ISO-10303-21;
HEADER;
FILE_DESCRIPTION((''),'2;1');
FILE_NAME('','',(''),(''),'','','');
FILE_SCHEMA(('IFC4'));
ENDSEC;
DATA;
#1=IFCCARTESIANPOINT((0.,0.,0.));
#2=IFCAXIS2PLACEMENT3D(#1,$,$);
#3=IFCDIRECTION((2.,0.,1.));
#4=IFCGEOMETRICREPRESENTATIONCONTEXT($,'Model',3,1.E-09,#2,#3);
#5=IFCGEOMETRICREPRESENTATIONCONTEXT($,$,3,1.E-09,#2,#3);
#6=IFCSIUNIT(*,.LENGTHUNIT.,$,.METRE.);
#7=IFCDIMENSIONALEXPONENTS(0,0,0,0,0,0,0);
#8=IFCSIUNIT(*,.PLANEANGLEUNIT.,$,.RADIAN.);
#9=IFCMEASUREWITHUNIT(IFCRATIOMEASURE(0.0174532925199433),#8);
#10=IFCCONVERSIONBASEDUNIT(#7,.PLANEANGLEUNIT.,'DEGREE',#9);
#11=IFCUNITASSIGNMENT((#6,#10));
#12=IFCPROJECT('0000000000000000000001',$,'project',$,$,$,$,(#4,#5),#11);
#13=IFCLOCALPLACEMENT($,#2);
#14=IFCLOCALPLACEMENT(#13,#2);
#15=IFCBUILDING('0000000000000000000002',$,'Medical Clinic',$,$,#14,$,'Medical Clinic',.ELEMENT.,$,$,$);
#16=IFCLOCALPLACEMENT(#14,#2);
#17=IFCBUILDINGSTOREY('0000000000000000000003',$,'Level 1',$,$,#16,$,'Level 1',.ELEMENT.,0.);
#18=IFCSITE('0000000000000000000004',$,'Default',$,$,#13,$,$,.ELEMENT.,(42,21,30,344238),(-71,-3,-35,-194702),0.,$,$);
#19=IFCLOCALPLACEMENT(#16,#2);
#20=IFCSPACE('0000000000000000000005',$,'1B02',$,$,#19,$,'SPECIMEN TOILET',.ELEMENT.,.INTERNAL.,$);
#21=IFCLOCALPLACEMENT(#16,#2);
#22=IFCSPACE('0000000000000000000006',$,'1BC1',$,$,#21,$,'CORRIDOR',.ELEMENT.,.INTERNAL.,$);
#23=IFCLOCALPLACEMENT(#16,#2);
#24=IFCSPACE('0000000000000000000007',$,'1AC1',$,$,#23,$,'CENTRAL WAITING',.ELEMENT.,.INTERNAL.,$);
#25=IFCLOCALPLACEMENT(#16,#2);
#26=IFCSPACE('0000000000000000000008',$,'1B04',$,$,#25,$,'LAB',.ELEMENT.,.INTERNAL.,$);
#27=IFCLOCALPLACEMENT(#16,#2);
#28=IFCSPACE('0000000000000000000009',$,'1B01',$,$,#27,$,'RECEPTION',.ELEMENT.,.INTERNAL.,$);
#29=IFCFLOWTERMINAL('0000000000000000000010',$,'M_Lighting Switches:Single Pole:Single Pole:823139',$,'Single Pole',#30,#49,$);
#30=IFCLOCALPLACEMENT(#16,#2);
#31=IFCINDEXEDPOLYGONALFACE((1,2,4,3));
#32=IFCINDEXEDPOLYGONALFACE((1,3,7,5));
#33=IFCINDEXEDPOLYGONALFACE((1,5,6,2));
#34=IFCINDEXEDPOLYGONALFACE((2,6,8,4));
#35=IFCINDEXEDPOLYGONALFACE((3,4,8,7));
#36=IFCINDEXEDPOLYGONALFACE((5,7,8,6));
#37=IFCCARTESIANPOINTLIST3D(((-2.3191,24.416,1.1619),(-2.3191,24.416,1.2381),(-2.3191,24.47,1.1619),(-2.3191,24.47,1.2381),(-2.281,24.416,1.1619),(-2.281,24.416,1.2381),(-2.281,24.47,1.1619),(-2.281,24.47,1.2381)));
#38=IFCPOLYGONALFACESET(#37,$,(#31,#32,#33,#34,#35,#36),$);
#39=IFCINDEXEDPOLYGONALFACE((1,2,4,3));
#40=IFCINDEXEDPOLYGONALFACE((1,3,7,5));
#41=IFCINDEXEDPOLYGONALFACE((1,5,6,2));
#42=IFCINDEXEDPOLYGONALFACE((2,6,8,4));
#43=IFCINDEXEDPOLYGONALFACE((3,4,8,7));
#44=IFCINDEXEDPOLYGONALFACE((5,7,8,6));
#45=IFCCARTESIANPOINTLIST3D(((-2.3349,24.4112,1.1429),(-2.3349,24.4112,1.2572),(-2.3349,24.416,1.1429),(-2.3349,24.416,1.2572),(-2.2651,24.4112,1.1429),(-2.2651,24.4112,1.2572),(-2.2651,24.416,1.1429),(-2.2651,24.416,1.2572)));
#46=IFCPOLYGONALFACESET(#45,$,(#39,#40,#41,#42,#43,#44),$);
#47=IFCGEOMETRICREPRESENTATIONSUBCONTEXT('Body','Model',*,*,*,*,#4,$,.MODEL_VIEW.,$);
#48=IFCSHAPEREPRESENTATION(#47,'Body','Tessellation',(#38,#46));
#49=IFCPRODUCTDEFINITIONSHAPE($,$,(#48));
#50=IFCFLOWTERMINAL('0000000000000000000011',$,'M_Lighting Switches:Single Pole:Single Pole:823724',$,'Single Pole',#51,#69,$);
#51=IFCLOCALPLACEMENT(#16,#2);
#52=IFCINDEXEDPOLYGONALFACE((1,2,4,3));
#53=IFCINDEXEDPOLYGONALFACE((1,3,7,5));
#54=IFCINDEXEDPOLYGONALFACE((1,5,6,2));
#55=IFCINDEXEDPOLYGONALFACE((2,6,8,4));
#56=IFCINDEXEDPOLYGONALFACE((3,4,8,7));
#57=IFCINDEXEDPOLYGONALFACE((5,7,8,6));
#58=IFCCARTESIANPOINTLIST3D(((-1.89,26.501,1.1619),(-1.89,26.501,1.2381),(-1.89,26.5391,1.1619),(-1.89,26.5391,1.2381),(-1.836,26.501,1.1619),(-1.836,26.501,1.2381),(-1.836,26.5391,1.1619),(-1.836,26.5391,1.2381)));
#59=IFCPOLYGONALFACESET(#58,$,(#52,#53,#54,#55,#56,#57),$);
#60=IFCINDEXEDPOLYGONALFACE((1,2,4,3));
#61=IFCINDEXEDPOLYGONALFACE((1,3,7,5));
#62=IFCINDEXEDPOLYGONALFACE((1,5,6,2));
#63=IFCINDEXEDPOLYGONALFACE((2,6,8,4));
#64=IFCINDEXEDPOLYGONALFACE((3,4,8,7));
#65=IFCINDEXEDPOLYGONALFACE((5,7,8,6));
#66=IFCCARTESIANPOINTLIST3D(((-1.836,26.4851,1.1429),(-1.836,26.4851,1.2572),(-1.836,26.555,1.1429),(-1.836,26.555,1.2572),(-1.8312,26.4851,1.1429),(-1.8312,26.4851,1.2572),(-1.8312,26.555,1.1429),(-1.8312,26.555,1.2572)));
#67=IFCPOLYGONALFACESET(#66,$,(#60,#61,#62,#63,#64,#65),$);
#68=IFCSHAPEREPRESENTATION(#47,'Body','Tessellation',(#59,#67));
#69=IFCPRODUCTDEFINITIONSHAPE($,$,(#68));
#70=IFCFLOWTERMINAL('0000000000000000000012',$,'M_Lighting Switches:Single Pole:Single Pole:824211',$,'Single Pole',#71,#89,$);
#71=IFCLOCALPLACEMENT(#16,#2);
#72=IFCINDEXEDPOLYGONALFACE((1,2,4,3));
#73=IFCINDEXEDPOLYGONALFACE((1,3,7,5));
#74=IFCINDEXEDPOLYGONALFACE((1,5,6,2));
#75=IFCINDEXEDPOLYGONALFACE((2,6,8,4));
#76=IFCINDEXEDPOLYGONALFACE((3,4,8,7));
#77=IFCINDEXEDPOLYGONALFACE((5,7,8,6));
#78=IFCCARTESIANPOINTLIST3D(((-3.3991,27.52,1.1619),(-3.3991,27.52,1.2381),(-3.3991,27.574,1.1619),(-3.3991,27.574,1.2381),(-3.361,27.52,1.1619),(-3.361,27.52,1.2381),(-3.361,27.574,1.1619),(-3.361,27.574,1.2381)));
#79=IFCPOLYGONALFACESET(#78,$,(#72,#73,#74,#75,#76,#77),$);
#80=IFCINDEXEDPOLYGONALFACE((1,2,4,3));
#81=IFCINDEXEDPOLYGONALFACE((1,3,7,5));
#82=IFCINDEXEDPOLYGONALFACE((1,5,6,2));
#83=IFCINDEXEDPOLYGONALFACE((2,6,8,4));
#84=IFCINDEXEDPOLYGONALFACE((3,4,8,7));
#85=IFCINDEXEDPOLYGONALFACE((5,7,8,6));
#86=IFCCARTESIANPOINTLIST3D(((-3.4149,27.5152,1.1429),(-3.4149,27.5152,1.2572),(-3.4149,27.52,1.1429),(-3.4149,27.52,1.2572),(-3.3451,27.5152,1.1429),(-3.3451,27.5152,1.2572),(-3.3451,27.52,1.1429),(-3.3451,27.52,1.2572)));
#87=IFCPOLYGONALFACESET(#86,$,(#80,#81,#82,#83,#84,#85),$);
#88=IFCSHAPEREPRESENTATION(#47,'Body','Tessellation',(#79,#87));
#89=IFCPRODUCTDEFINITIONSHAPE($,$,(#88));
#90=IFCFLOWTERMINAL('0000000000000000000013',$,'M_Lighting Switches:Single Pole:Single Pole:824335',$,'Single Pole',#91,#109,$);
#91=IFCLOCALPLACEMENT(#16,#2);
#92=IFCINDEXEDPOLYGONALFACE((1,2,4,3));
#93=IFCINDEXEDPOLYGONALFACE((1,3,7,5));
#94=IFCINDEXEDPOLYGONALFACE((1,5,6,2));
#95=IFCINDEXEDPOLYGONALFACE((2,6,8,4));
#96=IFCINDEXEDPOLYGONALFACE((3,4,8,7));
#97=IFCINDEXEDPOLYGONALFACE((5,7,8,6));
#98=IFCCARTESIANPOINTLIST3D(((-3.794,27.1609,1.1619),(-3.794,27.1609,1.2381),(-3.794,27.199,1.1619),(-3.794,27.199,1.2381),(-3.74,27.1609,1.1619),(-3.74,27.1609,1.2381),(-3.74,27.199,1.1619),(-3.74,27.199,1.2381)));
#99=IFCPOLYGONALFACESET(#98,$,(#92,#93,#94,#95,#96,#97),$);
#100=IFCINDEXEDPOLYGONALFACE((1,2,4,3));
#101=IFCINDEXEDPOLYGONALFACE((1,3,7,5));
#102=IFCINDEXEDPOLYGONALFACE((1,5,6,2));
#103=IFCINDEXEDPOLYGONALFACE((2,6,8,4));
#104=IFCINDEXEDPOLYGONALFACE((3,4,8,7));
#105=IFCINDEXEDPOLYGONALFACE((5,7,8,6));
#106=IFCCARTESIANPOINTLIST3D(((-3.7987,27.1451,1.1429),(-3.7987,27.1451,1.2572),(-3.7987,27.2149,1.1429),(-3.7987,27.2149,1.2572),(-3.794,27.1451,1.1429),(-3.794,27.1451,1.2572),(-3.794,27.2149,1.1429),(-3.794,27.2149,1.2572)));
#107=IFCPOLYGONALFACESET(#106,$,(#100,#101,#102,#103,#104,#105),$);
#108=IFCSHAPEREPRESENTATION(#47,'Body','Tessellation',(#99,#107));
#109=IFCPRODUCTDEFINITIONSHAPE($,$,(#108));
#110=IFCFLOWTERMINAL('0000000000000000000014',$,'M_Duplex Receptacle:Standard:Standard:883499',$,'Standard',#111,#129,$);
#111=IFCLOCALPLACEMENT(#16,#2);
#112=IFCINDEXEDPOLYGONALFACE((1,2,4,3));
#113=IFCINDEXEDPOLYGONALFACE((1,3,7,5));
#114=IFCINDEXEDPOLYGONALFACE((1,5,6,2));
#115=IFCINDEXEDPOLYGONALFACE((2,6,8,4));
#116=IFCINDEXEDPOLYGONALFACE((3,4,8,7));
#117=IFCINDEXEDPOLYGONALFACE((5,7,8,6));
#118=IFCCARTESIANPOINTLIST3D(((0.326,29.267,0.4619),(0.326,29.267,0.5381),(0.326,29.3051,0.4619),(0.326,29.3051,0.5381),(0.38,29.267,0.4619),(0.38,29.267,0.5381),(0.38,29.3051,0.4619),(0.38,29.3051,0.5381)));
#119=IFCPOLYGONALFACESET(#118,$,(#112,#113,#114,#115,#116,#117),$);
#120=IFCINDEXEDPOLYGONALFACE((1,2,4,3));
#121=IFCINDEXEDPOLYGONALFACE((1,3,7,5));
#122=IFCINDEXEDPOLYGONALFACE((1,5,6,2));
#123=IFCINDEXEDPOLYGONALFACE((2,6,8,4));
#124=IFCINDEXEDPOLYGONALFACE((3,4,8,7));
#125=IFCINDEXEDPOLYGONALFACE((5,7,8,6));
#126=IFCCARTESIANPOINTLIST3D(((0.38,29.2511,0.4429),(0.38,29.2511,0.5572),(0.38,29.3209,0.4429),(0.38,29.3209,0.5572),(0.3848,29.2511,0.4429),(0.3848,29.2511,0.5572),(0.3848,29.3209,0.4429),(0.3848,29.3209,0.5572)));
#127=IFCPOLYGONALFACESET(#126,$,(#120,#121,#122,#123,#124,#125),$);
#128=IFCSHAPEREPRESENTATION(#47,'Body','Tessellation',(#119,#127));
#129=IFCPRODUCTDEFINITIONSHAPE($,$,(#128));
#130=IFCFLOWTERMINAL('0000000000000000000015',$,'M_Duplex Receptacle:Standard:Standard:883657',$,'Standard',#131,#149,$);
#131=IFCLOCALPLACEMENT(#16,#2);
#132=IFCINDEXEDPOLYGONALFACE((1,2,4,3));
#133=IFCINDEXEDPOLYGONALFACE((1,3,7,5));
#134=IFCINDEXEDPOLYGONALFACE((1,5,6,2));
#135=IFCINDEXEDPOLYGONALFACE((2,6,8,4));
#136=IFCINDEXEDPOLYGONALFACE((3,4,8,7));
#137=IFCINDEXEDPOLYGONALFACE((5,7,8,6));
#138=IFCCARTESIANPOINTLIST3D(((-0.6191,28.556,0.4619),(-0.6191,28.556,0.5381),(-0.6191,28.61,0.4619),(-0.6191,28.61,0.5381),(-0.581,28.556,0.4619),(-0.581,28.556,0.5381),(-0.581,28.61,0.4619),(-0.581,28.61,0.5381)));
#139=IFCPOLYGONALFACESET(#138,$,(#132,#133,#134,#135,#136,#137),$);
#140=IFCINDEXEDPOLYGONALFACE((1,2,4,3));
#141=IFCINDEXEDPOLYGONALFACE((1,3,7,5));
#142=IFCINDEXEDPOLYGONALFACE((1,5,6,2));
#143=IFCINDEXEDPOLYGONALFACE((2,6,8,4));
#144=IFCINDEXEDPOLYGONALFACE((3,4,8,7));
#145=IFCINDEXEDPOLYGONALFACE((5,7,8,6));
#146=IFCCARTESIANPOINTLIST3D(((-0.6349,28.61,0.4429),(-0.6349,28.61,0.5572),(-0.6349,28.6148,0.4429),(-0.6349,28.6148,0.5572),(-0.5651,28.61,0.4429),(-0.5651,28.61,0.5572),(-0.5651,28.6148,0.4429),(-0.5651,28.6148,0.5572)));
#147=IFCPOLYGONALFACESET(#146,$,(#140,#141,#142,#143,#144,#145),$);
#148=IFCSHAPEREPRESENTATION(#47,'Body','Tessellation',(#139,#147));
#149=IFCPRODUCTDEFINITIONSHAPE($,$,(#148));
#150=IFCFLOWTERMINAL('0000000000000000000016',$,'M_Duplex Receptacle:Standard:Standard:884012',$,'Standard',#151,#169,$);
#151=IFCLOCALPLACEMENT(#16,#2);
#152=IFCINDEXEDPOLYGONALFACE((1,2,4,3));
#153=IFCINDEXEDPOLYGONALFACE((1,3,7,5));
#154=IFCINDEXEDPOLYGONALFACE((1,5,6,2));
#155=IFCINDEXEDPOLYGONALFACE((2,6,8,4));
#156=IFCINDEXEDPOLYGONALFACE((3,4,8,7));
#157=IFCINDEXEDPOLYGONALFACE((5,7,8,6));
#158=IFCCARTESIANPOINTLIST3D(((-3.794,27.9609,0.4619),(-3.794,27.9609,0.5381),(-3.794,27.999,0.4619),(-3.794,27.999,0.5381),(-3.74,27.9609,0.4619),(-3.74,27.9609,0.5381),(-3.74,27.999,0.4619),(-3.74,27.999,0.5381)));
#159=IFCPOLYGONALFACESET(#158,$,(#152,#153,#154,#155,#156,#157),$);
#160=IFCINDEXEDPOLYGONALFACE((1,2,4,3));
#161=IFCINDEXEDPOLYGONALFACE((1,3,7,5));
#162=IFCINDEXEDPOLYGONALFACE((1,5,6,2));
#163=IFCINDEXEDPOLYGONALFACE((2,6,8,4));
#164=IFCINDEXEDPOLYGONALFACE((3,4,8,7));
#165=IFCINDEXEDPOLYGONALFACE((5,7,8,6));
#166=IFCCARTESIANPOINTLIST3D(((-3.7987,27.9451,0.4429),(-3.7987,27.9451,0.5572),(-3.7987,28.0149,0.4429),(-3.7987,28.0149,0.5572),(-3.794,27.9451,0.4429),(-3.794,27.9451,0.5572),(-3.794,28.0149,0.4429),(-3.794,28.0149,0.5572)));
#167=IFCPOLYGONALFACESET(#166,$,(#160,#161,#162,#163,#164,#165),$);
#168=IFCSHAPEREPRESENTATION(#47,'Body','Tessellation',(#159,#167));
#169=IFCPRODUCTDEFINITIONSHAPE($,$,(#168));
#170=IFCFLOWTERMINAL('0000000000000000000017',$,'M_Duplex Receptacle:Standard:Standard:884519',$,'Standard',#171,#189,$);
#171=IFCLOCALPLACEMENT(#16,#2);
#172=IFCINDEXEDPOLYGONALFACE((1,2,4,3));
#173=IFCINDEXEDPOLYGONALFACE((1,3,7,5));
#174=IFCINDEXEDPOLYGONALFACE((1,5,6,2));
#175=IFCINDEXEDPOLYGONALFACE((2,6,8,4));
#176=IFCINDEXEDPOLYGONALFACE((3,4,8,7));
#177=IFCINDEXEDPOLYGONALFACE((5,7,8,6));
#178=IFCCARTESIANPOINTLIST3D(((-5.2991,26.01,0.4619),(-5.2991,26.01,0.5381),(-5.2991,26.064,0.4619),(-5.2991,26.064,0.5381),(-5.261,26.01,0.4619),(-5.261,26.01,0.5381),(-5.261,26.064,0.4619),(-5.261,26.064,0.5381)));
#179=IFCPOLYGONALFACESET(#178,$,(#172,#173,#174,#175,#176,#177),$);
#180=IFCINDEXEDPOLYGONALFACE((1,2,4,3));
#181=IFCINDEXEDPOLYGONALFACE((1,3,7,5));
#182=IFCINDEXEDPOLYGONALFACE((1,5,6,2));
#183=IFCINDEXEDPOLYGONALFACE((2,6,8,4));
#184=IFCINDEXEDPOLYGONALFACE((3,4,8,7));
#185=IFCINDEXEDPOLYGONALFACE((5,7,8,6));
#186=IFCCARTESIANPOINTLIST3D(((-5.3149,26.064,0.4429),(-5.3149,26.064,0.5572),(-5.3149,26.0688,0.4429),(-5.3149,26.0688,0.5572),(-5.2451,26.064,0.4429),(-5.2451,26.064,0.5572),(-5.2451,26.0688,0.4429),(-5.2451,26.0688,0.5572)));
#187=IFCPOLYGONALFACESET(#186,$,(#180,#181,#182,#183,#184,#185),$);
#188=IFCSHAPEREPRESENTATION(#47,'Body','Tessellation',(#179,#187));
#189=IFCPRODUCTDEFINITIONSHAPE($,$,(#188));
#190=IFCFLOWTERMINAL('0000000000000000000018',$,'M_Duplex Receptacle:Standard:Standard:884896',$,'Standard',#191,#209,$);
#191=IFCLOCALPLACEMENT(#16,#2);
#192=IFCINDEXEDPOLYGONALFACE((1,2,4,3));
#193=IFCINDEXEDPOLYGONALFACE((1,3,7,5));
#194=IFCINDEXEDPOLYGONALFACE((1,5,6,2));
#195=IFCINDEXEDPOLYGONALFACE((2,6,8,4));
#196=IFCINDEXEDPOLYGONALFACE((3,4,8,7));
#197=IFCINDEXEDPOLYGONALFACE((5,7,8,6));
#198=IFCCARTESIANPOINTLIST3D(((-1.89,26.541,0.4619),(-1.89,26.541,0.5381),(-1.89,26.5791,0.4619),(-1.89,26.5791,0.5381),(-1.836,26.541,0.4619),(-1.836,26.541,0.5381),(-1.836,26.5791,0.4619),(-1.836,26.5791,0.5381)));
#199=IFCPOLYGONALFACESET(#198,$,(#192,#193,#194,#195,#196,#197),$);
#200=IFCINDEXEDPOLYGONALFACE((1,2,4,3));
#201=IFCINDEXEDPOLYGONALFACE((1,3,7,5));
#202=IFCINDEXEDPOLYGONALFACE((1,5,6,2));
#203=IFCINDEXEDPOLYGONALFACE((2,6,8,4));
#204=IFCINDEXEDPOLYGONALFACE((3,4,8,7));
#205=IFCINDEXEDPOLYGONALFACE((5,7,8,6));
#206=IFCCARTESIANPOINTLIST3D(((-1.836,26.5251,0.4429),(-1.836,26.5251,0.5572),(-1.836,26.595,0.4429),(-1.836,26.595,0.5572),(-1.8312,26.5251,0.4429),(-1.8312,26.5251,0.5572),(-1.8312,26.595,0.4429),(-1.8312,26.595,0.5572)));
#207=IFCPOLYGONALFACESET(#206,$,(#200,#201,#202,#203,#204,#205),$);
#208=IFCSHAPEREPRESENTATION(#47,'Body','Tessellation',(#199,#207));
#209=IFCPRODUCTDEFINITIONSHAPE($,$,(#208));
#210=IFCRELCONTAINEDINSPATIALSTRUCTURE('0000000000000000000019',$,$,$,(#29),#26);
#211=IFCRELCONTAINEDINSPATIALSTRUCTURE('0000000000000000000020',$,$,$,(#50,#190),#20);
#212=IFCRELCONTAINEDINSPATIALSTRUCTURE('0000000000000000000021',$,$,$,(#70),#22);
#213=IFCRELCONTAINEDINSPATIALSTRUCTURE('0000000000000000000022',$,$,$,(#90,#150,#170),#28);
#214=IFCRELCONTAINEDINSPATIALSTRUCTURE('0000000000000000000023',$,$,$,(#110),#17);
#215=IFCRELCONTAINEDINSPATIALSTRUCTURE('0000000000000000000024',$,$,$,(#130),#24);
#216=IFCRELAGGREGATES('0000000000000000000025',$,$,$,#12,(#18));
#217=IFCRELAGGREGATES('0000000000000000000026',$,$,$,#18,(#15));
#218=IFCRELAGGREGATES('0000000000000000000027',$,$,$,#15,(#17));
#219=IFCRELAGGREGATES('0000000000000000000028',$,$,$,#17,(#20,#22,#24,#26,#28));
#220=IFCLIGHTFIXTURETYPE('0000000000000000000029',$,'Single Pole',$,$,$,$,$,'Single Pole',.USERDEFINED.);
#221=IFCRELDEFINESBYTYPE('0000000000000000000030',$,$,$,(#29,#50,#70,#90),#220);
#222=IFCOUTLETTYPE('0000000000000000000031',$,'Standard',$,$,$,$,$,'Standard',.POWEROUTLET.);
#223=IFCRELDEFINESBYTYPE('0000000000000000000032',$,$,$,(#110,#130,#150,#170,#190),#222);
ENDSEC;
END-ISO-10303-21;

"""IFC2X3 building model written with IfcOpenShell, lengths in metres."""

from ifc_helpers import new_model, entity, si_unit, converted_unit, direction, frame, frame_2d, origin, origin_2d_with_axis, place, context, subcontext, project, spatial, rectangle, extrude, source, transform, mapped, type_object, type_shapes, element, save


model = new_model("IFC2X3")

# Units and contexts
model_context = context("Model", 3, precision=1e-09, world=origin(), true_north=direction((2.0, 0.0, 1.0)))
context_of_model = context(None, 3, precision=1e-09, world=origin(), true_north=direction((2.0, 0.0, 1.0)))
body_context = subcontext(model_context, "Body", "Model", "MODEL_VIEW")
ifc_project = project(units=[si_unit("LENGTHUNIT", "METRE"), converted_unit("PLANEANGLEUNIT", "DEGREE", entity("IfcRatioMeasure", 0.0174532925199433), si_unit("PLANEANGLEUNIT", "RADIAN"), dimensions=[0, 0, 0, 0, 0, 0, 0])], contexts=[model_context, context_of_model])

# Site, building, storey, space
site_placement = place(None, origin())
site = spatial("IfcSite", under=ifc_project, at=site_placement, Name="Default", CompositionType="ELEMENT", RefLatitude=(42, 21, 30, 344238), RefLongitude=(-71, -3, -35, -194702), RefElevation=0.0)
building_placement = place(site_placement, origin())
building = spatial("IfcBuilding", under=site, at=building_placement, Name="Medical Clinic", LongName="Medical Clinic", CompositionType="ELEMENT")
storey_placement = place(building_placement, origin())
storey = spatial("IfcBuildingStorey", under=building, at=storey_placement, Name="Level 1", LongName="Level 1", CompositionType="ELEMENT", Elevation=0.0)
space_1_placement = place(storey_placement, origin())
space_1 = spatial("IfcSpace", under=storey, at=space_1_placement, Name="1B02", LongName="SPECIMEN TOILET", CompositionType="ELEMENT", InteriorOrExteriorSpace="INTERNAL")

# Shared definitions
space_2_placement = place(storey_placement, origin())
space_2 = spatial("IfcSpace", under=storey, at=space_2_placement, Name="1BC1", LongName="CORRIDOR", CompositionType="ELEMENT", InteriorOrExteriorSpace="INTERNAL")

# Shared definitions
space_3_placement = place(storey_placement, origin())
space_3 = spatial("IfcSpace", under=storey, at=space_3_placement, Name="1AC1", LongName="CENTRAL WAITING", CompositionType="ELEMENT", InteriorOrExteriorSpace="INTERNAL")

# Shared definitions
space_4_placement = place(storey_placement, origin())
space_4 = spatial("IfcSpace", under=storey, at=space_4_placement, Name="1B04", LongName="LAB", CompositionType="ELEMENT", InteriorOrExteriorSpace="INTERNAL")

# Flow terminals
light_fixture_type_1 = type_object("IfcLightFixtureType", Name="Single Pole", ElementType="Single Pole", PredefinedType="USERDEFINED")
shared_shape_1 = source(origin(), body_context, "Body", "SweptSolid", [
    extrude(rectangle(XDim=0.0381, YDim=0.0762, at=origin_2d_with_axis()), frame((0.0, 0.0, -0.054), z_axis=(0.0, 0.0, 1.0), x_axis=(-1.0, 0.0, 0.0)), (0.0, 0.0, 1.0), 0.054),
    extrude(rectangle(XDim=0.0698, YDim=0.1143, at=frame_2d((0.0, 0.0), x_axis=(1.0, 0.0))), frame((0.0, 0.0, 0.0), z_axis=(0.0, 0.0, 1.0), x_axis=(-1.0, 0.0, 0.0)), (0.0, 0.0, 1.0), 0.0048),
])
type_shapes(light_fixture_type_1, [shared_shape_1])
flow_terminal_1_placement = place(space_4_placement, frame((-2.3, 24.416, 1.2), z_axis=(0.0, -1.0, 0.0), x_axis=(1.0, 0.0, 0.0)))
element("IfcFlowTerminal", 1, at=flow_terminal_1_placement, inside=space_4, type_object=light_fixture_type_1, Name="M_Lighting Switches:Single Pole:Single Pole:823139", ObjectType="Single Pole", context=body_context, shape_type="MappedRepresentation", body=[
    mapped(shared_shape_1, transform((0.0, 0.0, 0.0), scale=1.0)),
])
flow_terminal_2_placement = place(space_1_placement, frame((-1.836, 26.5201, 1.2), z_axis=(1.0, 0.0, 0.0), x_axis=(0.0, 1.0, 0.0)))
element("IfcFlowTerminal", 2, at=flow_terminal_2_placement, inside=space_1, type_object=light_fixture_type_1, Name="M_Lighting Switches:Single Pole:Single Pole:823724", ObjectType="Single Pole", context=body_context, shape_type="MappedRepresentation", body=[
    mapped(shared_shape_1, transform((0.0, 0.0, 0.0), scale=1.0)),
])
flow_terminal_3_placement = place(space_2_placement, frame((-3.38, 27.52, 1.2), z_axis=(0.0, -1.0, 0.0), x_axis=(1.0, 0.0, 0.0)))
element("IfcFlowTerminal", 3, at=flow_terminal_3_placement, inside=space_2, type_object=light_fixture_type_1, Name="M_Lighting Switches:Single Pole:Single Pole:824211", ObjectType="Single Pole", context=body_context, shape_type="MappedRepresentation", body=[
    mapped(shared_shape_1, transform((0.0, 0.0, 0.0), scale=1.0)),
])

# Shared definitions
space_5_placement = place(storey_placement, origin())
space_5 = spatial("IfcSpace", under=storey, at=space_5_placement, Name="1B01", LongName="RECEPTION", CompositionType="ELEMENT", InteriorOrExteriorSpace="INTERNAL")

# Flow terminals
flow_terminal_4_placement = place(space_5_placement, frame((-3.794, 27.18, 1.2), z_axis=(-1.0, 0.0, 0.0), x_axis=(0.0, -1.0, 0.0)))
element("IfcFlowTerminal", 4, at=flow_terminal_4_placement, inside=space_5, type_object=light_fixture_type_1, Name="M_Lighting Switches:Single Pole:Single Pole:824335", ObjectType="Single Pole", context=body_context, shape_type="MappedRepresentation", body=[
    mapped(shared_shape_1, transform((0.0, 0.0, 0.0), scale=1.0)),
])
outlet_type = type_object("IfcOutletType", Name="Standard", ElementType="Standard", PredefinedType="POWEROUTLET")
shared_shape_2 = source(origin(), body_context, "Body", "SweptSolid", [
    extrude(rectangle(XDim=0.0381, YDim=0.0762, at=origin_2d_with_axis()), frame((0.0, 0.0, -0.054), z_axis=(0.0, 0.0, 1.0), x_axis=(-1.0, 0.0, 0.0)), (0.0, 0.0, 1.0), 0.054),
    extrude(rectangle(XDim=0.0698, YDim=0.1143, at=frame_2d((0.0, 0.0), x_axis=(1.0, 0.0))), frame((0.0, 0.0, 0.0), z_axis=(0.0, 0.0, 1.0), x_axis=(-1.0, 0.0, 0.0)), (0.0, 0.0, 1.0), 0.0048),
])
type_shapes(outlet_type, [shared_shape_2])
flow_terminal_5_placement = place(storey_placement, frame((0.38, 29.286, 0.5), z_axis=(1.0, 0.0, 0.0), x_axis=(0.0, 1.0, 0.0)))
element("IfcFlowTerminal", 5, at=flow_terminal_5_placement, inside=storey, type_object=outlet_type, Name="M_Duplex Receptacle:Standard:Standard:883499", ObjectType="Standard", context=body_context, shape_type="MappedRepresentation", body=[
    mapped(shared_shape_2, transform((0.0, 0.0, 0.0), scale=1.0)),
])
flow_terminal_6_placement = place(space_3_placement, frame((-0.6, 28.61, 0.5), z_axis=(0.0, 1.0, 0.0), x_axis=(-1.0, 0.0, 0.0)))
element("IfcFlowTerminal", 6, at=flow_terminal_6_placement, inside=space_3, type_object=outlet_type, Name="M_Duplex Receptacle:Standard:Standard:883657", ObjectType="Standard", context=body_context, shape_type="MappedRepresentation", body=[
    mapped(shared_shape_2, transform((0.0, 0.0, 0.0), scale=1.0)),
])
for number, where, z_axis, x_axis, name in (
    (7, (-3.794, 27.98, 0.5), (-1.0, 0.0, 0.0), (0.0, -1.0, 0.0), "M_Duplex Receptacle:Standard:Standard:884012"),
    (8, (-5.28, 26.064, 0.5), (0.0, 1.0, 0.0), (-1.0, 0.0, 0.0), "M_Duplex Receptacle:Standard:Standard:884519"),
):
    element("IfcFlowTerminal", number, at=place(space_5_placement, frame(where, z_axis=z_axis, x_axis=x_axis)), inside=space_5, type_object=outlet_type, Name=name, ObjectType="Standard", context=body_context, shape_type="MappedRepresentation", body=[
        mapped(shared_shape_2, transform((0.0, 0.0, 0.0), scale=1.0)),
    ])
flow_terminal_7_placement = place(space_1_placement, frame((-1.836, 26.5601, 0.5), z_axis=(1.0, 0.0, 0.0), x_axis=(0.0, 1.0, 0.0)))
element("IfcFlowTerminal", 9, at=flow_terminal_7_placement, inside=space_1, type_object=outlet_type, Name="M_Duplex Receptacle:Standard:Standard:884896", ObjectType="Standard", context=body_context, shape_type="MappedRepresentation", body=[
    mapped(shared_shape_2, transform((0.0, 0.0, 0.0), scale=1.0)),
])

save(model, "model.ifc")
